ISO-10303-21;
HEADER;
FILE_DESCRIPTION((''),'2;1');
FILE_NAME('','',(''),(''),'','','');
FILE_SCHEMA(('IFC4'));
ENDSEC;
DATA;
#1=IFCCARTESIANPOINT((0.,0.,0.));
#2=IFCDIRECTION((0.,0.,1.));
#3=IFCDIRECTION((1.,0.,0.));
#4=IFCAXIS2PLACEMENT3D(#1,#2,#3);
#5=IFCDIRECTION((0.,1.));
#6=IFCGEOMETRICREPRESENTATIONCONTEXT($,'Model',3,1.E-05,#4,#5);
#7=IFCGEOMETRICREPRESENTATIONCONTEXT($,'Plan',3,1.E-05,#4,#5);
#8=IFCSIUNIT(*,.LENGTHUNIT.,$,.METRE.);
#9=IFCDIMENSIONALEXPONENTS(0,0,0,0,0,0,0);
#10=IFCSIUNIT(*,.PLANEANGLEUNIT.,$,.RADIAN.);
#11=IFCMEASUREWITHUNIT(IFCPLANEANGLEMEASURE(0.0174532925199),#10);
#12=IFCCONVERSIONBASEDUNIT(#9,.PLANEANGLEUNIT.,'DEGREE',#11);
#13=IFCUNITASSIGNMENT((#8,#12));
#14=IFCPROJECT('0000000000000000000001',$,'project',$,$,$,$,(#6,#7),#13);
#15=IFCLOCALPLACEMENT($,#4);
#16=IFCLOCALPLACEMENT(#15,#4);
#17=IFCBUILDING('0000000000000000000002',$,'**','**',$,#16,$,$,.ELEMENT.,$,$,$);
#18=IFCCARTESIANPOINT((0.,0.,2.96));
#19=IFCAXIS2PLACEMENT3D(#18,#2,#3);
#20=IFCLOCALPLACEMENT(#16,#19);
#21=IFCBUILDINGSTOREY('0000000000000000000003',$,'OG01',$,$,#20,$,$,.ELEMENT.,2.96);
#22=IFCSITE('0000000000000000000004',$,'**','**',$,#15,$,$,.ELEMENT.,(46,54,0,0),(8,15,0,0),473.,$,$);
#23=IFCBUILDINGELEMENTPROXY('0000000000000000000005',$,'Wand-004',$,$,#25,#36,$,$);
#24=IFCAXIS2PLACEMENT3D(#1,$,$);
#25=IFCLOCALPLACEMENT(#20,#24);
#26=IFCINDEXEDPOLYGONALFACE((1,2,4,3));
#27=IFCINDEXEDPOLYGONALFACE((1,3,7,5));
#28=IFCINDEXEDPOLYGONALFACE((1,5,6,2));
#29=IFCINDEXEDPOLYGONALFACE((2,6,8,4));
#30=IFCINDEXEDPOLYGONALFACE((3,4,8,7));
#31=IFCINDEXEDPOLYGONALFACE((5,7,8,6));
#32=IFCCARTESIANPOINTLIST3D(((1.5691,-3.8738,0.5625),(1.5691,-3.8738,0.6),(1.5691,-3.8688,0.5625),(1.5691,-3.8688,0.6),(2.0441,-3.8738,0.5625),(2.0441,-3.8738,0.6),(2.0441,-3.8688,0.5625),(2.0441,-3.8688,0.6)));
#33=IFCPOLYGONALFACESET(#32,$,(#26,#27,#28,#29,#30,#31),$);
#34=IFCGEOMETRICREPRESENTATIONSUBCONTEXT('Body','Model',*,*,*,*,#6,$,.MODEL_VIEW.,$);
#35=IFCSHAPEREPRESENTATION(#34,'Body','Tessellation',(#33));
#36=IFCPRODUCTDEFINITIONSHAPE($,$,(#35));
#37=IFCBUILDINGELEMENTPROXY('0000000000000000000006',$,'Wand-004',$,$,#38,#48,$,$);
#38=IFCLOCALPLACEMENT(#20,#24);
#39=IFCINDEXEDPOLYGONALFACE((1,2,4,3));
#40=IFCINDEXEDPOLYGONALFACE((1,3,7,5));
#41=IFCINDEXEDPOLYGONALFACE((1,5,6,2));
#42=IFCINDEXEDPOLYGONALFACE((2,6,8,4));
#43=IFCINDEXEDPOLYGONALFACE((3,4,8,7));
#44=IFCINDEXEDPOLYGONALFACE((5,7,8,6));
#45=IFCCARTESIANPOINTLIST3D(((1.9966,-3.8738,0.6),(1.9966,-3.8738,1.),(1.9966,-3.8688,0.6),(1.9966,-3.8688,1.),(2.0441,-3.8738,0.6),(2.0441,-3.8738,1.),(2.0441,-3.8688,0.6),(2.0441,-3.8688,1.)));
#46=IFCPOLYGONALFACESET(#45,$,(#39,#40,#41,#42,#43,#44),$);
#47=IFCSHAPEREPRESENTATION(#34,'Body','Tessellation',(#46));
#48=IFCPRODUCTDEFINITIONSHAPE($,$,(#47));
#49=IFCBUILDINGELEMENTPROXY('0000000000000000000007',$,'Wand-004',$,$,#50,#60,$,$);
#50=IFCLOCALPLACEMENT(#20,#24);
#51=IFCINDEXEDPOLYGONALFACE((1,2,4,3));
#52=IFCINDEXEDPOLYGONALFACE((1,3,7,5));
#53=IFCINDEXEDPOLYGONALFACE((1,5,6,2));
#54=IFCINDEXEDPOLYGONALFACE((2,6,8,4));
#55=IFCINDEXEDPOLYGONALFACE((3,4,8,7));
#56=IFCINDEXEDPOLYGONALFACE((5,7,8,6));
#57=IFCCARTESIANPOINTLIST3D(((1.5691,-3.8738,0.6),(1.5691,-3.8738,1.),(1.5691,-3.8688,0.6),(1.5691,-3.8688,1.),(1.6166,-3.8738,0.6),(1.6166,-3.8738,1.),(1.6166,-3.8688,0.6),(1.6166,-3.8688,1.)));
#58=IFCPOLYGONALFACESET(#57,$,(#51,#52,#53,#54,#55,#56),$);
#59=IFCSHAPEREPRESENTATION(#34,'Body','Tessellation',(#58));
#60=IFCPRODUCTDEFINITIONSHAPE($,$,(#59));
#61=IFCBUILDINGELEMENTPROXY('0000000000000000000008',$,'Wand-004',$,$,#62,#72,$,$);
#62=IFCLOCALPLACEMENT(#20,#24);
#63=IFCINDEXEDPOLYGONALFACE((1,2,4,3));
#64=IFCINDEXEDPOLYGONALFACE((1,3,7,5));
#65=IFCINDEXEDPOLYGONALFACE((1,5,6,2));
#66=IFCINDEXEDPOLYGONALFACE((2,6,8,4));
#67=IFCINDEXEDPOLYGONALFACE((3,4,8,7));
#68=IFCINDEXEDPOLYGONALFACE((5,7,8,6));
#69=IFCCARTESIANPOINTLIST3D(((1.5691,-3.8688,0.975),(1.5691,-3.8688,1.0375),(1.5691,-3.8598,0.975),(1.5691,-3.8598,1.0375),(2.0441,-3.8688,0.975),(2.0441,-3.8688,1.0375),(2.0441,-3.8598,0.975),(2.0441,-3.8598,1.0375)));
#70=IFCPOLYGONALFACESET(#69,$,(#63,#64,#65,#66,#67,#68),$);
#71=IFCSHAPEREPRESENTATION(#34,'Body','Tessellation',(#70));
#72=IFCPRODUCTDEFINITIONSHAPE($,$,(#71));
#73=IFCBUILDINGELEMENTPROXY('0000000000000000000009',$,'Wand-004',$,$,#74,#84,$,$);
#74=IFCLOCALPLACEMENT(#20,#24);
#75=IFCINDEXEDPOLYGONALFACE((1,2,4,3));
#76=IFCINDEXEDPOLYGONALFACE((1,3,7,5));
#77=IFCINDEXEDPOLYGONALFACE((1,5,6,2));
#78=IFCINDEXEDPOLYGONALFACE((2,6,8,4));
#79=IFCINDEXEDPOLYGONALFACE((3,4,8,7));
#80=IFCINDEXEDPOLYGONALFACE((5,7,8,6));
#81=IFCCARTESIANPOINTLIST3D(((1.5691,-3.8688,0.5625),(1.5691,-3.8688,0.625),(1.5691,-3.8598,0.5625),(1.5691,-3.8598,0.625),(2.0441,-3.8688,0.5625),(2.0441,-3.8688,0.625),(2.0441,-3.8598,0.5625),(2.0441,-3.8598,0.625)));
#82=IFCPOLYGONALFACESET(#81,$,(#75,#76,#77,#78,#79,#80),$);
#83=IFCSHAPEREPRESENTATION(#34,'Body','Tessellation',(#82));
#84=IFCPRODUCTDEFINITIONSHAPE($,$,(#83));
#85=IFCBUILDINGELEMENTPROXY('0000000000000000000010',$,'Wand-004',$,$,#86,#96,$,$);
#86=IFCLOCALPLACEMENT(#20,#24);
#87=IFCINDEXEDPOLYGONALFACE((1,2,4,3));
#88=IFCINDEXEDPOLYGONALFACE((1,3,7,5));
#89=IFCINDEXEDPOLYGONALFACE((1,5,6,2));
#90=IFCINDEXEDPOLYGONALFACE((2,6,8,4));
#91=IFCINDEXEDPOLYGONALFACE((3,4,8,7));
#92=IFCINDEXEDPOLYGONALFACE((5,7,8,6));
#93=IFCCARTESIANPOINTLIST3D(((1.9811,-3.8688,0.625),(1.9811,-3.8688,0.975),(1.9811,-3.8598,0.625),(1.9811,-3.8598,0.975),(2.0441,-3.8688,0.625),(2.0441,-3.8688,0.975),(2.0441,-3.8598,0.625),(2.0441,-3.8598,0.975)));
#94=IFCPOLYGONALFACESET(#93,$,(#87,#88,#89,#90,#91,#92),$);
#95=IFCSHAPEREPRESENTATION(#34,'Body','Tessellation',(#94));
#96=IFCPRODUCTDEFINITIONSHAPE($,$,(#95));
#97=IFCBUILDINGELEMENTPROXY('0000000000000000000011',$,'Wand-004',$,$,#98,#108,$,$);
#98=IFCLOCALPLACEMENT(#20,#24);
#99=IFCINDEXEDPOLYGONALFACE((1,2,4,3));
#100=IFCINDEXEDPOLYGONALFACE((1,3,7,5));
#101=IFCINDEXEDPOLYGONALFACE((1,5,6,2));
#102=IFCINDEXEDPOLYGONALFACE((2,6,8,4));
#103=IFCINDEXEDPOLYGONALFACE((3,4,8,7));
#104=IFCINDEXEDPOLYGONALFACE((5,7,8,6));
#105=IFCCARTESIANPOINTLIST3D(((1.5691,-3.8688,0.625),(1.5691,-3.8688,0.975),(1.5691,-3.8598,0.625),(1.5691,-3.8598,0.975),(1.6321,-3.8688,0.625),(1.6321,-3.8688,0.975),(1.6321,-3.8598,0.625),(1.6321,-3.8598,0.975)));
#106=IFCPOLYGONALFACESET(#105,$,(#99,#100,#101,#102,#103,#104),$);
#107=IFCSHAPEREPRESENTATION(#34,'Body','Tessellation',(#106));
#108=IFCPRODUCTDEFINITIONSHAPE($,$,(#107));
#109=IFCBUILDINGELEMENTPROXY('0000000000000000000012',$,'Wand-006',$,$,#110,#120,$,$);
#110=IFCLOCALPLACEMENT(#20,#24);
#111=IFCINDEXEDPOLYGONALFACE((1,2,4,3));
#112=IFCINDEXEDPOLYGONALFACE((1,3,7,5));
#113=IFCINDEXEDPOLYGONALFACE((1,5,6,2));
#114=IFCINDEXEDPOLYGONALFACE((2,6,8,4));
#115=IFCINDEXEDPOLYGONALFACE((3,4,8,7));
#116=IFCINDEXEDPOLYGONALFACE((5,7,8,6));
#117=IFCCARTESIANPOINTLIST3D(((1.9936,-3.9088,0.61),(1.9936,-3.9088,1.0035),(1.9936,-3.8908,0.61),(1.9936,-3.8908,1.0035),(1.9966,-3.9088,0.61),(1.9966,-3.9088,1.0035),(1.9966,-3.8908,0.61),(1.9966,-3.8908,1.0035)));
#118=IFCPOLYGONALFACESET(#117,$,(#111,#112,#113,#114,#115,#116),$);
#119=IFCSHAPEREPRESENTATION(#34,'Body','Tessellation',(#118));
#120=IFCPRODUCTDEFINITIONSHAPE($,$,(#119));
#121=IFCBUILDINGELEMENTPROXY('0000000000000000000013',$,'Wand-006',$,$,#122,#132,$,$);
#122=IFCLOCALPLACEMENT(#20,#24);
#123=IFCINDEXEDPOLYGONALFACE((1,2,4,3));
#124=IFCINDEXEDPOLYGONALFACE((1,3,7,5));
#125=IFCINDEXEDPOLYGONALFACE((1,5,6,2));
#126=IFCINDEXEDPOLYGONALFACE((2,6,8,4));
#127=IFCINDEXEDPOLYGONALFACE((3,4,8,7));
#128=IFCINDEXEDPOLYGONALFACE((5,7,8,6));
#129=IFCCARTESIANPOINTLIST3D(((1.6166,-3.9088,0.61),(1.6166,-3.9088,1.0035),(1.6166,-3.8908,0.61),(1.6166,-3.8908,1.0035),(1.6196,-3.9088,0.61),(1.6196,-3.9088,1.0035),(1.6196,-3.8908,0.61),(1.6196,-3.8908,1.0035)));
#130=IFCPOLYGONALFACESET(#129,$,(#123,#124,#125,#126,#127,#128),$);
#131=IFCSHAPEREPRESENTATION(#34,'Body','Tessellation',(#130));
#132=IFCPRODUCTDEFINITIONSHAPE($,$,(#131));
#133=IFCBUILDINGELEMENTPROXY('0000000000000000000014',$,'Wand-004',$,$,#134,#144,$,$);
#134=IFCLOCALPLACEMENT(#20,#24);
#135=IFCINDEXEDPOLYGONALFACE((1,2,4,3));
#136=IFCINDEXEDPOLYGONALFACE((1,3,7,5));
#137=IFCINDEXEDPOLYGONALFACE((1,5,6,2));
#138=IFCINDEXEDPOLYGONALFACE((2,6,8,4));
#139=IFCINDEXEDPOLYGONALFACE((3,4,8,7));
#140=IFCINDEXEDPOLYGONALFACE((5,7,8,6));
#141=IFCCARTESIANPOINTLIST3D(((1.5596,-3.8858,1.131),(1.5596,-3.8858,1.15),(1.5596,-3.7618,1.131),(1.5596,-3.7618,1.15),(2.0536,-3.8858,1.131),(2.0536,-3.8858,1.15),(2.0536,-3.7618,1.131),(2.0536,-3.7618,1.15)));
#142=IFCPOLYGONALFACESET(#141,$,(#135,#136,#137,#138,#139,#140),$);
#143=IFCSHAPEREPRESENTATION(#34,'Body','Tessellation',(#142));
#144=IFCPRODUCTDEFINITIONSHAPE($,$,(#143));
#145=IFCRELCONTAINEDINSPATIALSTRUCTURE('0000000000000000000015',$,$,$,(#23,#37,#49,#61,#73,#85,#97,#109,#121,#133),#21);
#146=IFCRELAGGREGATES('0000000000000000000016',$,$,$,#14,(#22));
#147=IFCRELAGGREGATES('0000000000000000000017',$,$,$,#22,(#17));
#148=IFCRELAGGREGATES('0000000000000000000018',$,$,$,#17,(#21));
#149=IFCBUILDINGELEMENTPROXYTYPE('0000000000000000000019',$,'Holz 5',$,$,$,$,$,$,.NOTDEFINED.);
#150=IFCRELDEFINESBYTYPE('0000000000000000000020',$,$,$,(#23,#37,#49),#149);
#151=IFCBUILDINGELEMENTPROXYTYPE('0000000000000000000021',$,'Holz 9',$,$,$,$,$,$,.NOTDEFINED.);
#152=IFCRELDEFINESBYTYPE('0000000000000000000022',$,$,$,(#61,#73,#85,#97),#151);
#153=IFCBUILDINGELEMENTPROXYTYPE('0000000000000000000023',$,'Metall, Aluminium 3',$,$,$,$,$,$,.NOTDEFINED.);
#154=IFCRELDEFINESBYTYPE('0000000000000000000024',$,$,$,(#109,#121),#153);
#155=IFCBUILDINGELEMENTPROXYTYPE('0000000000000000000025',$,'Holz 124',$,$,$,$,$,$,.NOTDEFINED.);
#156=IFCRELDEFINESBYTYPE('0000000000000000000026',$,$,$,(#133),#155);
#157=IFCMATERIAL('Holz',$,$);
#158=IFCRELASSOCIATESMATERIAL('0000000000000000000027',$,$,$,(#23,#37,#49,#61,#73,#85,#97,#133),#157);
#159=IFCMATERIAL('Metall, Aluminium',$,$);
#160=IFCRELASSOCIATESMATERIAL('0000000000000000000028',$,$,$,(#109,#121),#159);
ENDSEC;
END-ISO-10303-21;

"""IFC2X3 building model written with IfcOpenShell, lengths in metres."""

from ifc_helpers import new_model, entity, si_unit, converted_unit, direction, frame, origin_with_axes, place, context, subcontext, project, spatial, polyline, outline, extrude, material, type_object, element, save


model = new_model("IFC2X3")

# Units and contexts
model_context = context("Model", 3, precision=1e-05, world=origin_with_axes(), true_north=direction((0.0, 1.0)))
plan_context = context("Plan", 3, precision=1e-05, world=origin_with_axes(), true_north=direction((0.0, 1.0)))
body_context = subcontext(model_context, "Body", "Model", "MODEL_VIEW")
ifc_project = project(units=[si_unit("LENGTHUNIT", "METRE"), converted_unit("PLANEANGLEUNIT", "DEGREE", entity("IfcPlaneAngleMeasure", 0.0174532925199), si_unit("PLANEANGLEUNIT", "RADIAN"), dimensions=[0, 0, 0, 0, 0, 0, 0])], contexts=[model_context, plan_context])

# Site, building, storey
site_placement = place(None, origin_with_axes())
site = spatial("IfcSite", under=ifc_project, at=site_placement, Name="**", Description="**", CompositionType="ELEMENT", RefLatitude=(46, 54, 0, 0), RefLongitude=(8, 15, 0, 0), RefElevation=473.0)
building_placement = place(site_placement, origin_with_axes())
building = spatial("IfcBuilding", under=site, at=building_placement, Name="**", Description="**", CompositionType="ELEMENT")
storey_placement = place(building_placement, frame((0.0, 0.0, 2.96), z_axis=(0.0, 0.0, 1.0), x_axis=(1.0, 0.0, 0.0)))
storey = spatial("IfcBuildingStorey", under=building, at=storey_placement, Name="OG01", CompositionType="ELEMENT", Elevation=2.96)

# Shared definitions
ifc_material_1 = material(Name="Holz")

# Building element proxies
building_element_proxy_type_1 = type_object("IfcBuildingElementProxyType", Name="Holz 5", PredefinedType="NOTDEFINED")
for number, where, z_axis, x_axis, name in (
    (1, (2.0441, -3.8738, 0.5625), (0.0, 0.0, 1.0), (-1.0, 0.0, 0.0), "Wand-004"),
):
    element("IfcBuildingElementProxy", number, at=place(storey_placement, frame(where, z_axis=z_axis, x_axis=x_axis)), inside=storey, type_object=building_element_proxy_type_1, material=ifc_material_1, Name=name, context=body_context, shape_type="SweptSolid", body=[
        extrude(outline(polyline([(0.0, -0.005), (0.475, -0.005), (0.475, 0.0), (0.0, 0.0), (0.0, -0.005)])), origin_with_axes(), (0.0, 0.0, 1.0), 0.0375),
    ])
for number, where, z_axis, x_axis, name in (
    (2, (1.9966, -3.8738, 0.6), (0.0, 0.0, 1.0), (1.0, 0.0, 0.0), "Wand-004"),
    (3, (1.5691, -3.8738, 0.6), (0.0, 0.0, 1.0), (1.0, 0.0, 0.0), "Wand-004"),
):
    element("IfcBuildingElementProxy", number, at=place(storey_placement, frame(where, z_axis=z_axis, x_axis=x_axis)), inside=storey, type_object=building_element_proxy_type_1, material=ifc_material_1, Name=name, context=body_context, shape_type="SweptSolid", body=[
        extrude(outline(polyline([(0.0, 0.0), (0.0475, 0.0), (0.0475, 0.005), (0.0, 0.005), (0.0, 0.0)])), origin_with_axes(), (0.0, 0.0, 1.0), 0.4),
    ])
building_element_proxy_type_2 = type_object("IfcBuildingElementProxyType", Name="Holz 9", PredefinedType="NOTDEFINED")
for number, where, z_axis, x_axis, name in (
    (4, (2.0441, -3.8688, 0.975), (0.0, 0.0, 1.0), (-1.0, 0.0, 0.0), "Wand-004"),
    (5, (2.0441, -3.8688, 0.5625), (0.0, 0.0, 1.0), (-1.0, 0.0, 0.0), "Wand-004"),
):
    element("IfcBuildingElementProxy", number, at=place(storey_placement, frame(where, z_axis=z_axis, x_axis=x_axis)), inside=storey, type_object=building_element_proxy_type_2, material=ifc_material_1, Name=name, context=body_context, shape_type="SweptSolid", body=[
        extrude(outline(polyline([(0.0, -0.009), (0.475, -0.009), (0.475, 0.0), (0.0, 0.0), (0.0, -0.009)])), origin_with_axes(), (0.0, 0.0, 1.0), 0.0625),
    ])
for number, where, z_axis, x_axis, name in (
    (6, (1.9811, -3.8688, 0.625), (0.0, 0.0, 1.0), (1.0, 0.0, 0.0), "Wand-004"),
    (7, (1.5691, -3.8688, 0.625), (0.0, 0.0, 1.0), (1.0, 0.0, 0.0), "Wand-004"),
):
    element("IfcBuildingElementProxy", number, at=place(storey_placement, frame(where, z_axis=z_axis, x_axis=x_axis)), inside=storey, type_object=building_element_proxy_type_2, material=ifc_material_1, Name=name, context=body_context, shape_type="SweptSolid", body=[
        extrude(outline(polyline([(0.0, 0.0), (0.063, 0.0), (0.063, 0.009), (0.0, 0.009), (0.0, 0.0)])), origin_with_axes(), (0.0, 0.0, 1.0), 0.35),
    ])
ifc_material_2 = material(Name="Metall, Aluminium")
building_element_proxy_type_3 = type_object("IfcBuildingElementProxyType", Name="Metall, Aluminium 3", PredefinedType="NOTDEFINED")
proxy_1_placement = place(storey_placement, frame((1.9966, -3.8908, 0.61), z_axis=(0.0, 0.0, 1.0), x_axis=(0.0, -1.0, 0.0)))
element("IfcBuildingElementProxy", 8, at=proxy_1_placement, inside=storey, type_object=building_element_proxy_type_3, material=ifc_material_2, Name="Wand-006", context=body_context, shape_type="SweptSolid", body=[
    extrude(outline(polyline([(0.0, -0.003), (0.018, -0.003), (0.018, 0.0), (0.0, 0.0), (0.0, -0.003)])), origin_with_axes(), (0.0, 0.0, 1.0), 0.3935),
])
proxy_2_placement = place(storey_placement, frame((1.6166, -3.8908, 0.61), z_axis=(0.0, 0.0, 1.0), x_axis=(0.0, -1.0, 0.0)))
element("IfcBuildingElementProxy", 9, at=proxy_2_placement, inside=storey, type_object=building_element_proxy_type_3, material=ifc_material_2, Name="Wand-006", context=body_context, shape_type="SweptSolid", body=[
    extrude(outline(polyline([(0.0, 0.0), (0.018, 0.0), (0.018, 0.003), (0.0, 0.003), (0.0, 0.0)])), origin_with_axes(), (0.0, 0.0, 1.0), 0.3935),
])
building_element_proxy_type_4 = type_object("IfcBuildingElementProxyType", Name="Holz 124", PredefinedType="NOTDEFINED")
proxy_3_placement = place(storey_placement, frame((1.5596, -3.7618, 1.131), z_axis=(0.0, 0.0, 1.0), x_axis=(1.0, 0.0, 0.0)))
element("IfcBuildingElementProxy", 10, at=proxy_3_placement, inside=storey, type_object=building_element_proxy_type_4, material=ifc_material_1, Name="Wand-004", context=body_context, shape_type="SweptSolid", body=[
    extrude(outline(polyline([(0.0, -0.124), (0.494, -0.124), (0.494, 0.0), (0.0, 0.0), (0.0, -0.124)])), origin_with_axes(), (0.0, 0.0, 1.0), 0.019),
])

save(model, "model.ifc")
